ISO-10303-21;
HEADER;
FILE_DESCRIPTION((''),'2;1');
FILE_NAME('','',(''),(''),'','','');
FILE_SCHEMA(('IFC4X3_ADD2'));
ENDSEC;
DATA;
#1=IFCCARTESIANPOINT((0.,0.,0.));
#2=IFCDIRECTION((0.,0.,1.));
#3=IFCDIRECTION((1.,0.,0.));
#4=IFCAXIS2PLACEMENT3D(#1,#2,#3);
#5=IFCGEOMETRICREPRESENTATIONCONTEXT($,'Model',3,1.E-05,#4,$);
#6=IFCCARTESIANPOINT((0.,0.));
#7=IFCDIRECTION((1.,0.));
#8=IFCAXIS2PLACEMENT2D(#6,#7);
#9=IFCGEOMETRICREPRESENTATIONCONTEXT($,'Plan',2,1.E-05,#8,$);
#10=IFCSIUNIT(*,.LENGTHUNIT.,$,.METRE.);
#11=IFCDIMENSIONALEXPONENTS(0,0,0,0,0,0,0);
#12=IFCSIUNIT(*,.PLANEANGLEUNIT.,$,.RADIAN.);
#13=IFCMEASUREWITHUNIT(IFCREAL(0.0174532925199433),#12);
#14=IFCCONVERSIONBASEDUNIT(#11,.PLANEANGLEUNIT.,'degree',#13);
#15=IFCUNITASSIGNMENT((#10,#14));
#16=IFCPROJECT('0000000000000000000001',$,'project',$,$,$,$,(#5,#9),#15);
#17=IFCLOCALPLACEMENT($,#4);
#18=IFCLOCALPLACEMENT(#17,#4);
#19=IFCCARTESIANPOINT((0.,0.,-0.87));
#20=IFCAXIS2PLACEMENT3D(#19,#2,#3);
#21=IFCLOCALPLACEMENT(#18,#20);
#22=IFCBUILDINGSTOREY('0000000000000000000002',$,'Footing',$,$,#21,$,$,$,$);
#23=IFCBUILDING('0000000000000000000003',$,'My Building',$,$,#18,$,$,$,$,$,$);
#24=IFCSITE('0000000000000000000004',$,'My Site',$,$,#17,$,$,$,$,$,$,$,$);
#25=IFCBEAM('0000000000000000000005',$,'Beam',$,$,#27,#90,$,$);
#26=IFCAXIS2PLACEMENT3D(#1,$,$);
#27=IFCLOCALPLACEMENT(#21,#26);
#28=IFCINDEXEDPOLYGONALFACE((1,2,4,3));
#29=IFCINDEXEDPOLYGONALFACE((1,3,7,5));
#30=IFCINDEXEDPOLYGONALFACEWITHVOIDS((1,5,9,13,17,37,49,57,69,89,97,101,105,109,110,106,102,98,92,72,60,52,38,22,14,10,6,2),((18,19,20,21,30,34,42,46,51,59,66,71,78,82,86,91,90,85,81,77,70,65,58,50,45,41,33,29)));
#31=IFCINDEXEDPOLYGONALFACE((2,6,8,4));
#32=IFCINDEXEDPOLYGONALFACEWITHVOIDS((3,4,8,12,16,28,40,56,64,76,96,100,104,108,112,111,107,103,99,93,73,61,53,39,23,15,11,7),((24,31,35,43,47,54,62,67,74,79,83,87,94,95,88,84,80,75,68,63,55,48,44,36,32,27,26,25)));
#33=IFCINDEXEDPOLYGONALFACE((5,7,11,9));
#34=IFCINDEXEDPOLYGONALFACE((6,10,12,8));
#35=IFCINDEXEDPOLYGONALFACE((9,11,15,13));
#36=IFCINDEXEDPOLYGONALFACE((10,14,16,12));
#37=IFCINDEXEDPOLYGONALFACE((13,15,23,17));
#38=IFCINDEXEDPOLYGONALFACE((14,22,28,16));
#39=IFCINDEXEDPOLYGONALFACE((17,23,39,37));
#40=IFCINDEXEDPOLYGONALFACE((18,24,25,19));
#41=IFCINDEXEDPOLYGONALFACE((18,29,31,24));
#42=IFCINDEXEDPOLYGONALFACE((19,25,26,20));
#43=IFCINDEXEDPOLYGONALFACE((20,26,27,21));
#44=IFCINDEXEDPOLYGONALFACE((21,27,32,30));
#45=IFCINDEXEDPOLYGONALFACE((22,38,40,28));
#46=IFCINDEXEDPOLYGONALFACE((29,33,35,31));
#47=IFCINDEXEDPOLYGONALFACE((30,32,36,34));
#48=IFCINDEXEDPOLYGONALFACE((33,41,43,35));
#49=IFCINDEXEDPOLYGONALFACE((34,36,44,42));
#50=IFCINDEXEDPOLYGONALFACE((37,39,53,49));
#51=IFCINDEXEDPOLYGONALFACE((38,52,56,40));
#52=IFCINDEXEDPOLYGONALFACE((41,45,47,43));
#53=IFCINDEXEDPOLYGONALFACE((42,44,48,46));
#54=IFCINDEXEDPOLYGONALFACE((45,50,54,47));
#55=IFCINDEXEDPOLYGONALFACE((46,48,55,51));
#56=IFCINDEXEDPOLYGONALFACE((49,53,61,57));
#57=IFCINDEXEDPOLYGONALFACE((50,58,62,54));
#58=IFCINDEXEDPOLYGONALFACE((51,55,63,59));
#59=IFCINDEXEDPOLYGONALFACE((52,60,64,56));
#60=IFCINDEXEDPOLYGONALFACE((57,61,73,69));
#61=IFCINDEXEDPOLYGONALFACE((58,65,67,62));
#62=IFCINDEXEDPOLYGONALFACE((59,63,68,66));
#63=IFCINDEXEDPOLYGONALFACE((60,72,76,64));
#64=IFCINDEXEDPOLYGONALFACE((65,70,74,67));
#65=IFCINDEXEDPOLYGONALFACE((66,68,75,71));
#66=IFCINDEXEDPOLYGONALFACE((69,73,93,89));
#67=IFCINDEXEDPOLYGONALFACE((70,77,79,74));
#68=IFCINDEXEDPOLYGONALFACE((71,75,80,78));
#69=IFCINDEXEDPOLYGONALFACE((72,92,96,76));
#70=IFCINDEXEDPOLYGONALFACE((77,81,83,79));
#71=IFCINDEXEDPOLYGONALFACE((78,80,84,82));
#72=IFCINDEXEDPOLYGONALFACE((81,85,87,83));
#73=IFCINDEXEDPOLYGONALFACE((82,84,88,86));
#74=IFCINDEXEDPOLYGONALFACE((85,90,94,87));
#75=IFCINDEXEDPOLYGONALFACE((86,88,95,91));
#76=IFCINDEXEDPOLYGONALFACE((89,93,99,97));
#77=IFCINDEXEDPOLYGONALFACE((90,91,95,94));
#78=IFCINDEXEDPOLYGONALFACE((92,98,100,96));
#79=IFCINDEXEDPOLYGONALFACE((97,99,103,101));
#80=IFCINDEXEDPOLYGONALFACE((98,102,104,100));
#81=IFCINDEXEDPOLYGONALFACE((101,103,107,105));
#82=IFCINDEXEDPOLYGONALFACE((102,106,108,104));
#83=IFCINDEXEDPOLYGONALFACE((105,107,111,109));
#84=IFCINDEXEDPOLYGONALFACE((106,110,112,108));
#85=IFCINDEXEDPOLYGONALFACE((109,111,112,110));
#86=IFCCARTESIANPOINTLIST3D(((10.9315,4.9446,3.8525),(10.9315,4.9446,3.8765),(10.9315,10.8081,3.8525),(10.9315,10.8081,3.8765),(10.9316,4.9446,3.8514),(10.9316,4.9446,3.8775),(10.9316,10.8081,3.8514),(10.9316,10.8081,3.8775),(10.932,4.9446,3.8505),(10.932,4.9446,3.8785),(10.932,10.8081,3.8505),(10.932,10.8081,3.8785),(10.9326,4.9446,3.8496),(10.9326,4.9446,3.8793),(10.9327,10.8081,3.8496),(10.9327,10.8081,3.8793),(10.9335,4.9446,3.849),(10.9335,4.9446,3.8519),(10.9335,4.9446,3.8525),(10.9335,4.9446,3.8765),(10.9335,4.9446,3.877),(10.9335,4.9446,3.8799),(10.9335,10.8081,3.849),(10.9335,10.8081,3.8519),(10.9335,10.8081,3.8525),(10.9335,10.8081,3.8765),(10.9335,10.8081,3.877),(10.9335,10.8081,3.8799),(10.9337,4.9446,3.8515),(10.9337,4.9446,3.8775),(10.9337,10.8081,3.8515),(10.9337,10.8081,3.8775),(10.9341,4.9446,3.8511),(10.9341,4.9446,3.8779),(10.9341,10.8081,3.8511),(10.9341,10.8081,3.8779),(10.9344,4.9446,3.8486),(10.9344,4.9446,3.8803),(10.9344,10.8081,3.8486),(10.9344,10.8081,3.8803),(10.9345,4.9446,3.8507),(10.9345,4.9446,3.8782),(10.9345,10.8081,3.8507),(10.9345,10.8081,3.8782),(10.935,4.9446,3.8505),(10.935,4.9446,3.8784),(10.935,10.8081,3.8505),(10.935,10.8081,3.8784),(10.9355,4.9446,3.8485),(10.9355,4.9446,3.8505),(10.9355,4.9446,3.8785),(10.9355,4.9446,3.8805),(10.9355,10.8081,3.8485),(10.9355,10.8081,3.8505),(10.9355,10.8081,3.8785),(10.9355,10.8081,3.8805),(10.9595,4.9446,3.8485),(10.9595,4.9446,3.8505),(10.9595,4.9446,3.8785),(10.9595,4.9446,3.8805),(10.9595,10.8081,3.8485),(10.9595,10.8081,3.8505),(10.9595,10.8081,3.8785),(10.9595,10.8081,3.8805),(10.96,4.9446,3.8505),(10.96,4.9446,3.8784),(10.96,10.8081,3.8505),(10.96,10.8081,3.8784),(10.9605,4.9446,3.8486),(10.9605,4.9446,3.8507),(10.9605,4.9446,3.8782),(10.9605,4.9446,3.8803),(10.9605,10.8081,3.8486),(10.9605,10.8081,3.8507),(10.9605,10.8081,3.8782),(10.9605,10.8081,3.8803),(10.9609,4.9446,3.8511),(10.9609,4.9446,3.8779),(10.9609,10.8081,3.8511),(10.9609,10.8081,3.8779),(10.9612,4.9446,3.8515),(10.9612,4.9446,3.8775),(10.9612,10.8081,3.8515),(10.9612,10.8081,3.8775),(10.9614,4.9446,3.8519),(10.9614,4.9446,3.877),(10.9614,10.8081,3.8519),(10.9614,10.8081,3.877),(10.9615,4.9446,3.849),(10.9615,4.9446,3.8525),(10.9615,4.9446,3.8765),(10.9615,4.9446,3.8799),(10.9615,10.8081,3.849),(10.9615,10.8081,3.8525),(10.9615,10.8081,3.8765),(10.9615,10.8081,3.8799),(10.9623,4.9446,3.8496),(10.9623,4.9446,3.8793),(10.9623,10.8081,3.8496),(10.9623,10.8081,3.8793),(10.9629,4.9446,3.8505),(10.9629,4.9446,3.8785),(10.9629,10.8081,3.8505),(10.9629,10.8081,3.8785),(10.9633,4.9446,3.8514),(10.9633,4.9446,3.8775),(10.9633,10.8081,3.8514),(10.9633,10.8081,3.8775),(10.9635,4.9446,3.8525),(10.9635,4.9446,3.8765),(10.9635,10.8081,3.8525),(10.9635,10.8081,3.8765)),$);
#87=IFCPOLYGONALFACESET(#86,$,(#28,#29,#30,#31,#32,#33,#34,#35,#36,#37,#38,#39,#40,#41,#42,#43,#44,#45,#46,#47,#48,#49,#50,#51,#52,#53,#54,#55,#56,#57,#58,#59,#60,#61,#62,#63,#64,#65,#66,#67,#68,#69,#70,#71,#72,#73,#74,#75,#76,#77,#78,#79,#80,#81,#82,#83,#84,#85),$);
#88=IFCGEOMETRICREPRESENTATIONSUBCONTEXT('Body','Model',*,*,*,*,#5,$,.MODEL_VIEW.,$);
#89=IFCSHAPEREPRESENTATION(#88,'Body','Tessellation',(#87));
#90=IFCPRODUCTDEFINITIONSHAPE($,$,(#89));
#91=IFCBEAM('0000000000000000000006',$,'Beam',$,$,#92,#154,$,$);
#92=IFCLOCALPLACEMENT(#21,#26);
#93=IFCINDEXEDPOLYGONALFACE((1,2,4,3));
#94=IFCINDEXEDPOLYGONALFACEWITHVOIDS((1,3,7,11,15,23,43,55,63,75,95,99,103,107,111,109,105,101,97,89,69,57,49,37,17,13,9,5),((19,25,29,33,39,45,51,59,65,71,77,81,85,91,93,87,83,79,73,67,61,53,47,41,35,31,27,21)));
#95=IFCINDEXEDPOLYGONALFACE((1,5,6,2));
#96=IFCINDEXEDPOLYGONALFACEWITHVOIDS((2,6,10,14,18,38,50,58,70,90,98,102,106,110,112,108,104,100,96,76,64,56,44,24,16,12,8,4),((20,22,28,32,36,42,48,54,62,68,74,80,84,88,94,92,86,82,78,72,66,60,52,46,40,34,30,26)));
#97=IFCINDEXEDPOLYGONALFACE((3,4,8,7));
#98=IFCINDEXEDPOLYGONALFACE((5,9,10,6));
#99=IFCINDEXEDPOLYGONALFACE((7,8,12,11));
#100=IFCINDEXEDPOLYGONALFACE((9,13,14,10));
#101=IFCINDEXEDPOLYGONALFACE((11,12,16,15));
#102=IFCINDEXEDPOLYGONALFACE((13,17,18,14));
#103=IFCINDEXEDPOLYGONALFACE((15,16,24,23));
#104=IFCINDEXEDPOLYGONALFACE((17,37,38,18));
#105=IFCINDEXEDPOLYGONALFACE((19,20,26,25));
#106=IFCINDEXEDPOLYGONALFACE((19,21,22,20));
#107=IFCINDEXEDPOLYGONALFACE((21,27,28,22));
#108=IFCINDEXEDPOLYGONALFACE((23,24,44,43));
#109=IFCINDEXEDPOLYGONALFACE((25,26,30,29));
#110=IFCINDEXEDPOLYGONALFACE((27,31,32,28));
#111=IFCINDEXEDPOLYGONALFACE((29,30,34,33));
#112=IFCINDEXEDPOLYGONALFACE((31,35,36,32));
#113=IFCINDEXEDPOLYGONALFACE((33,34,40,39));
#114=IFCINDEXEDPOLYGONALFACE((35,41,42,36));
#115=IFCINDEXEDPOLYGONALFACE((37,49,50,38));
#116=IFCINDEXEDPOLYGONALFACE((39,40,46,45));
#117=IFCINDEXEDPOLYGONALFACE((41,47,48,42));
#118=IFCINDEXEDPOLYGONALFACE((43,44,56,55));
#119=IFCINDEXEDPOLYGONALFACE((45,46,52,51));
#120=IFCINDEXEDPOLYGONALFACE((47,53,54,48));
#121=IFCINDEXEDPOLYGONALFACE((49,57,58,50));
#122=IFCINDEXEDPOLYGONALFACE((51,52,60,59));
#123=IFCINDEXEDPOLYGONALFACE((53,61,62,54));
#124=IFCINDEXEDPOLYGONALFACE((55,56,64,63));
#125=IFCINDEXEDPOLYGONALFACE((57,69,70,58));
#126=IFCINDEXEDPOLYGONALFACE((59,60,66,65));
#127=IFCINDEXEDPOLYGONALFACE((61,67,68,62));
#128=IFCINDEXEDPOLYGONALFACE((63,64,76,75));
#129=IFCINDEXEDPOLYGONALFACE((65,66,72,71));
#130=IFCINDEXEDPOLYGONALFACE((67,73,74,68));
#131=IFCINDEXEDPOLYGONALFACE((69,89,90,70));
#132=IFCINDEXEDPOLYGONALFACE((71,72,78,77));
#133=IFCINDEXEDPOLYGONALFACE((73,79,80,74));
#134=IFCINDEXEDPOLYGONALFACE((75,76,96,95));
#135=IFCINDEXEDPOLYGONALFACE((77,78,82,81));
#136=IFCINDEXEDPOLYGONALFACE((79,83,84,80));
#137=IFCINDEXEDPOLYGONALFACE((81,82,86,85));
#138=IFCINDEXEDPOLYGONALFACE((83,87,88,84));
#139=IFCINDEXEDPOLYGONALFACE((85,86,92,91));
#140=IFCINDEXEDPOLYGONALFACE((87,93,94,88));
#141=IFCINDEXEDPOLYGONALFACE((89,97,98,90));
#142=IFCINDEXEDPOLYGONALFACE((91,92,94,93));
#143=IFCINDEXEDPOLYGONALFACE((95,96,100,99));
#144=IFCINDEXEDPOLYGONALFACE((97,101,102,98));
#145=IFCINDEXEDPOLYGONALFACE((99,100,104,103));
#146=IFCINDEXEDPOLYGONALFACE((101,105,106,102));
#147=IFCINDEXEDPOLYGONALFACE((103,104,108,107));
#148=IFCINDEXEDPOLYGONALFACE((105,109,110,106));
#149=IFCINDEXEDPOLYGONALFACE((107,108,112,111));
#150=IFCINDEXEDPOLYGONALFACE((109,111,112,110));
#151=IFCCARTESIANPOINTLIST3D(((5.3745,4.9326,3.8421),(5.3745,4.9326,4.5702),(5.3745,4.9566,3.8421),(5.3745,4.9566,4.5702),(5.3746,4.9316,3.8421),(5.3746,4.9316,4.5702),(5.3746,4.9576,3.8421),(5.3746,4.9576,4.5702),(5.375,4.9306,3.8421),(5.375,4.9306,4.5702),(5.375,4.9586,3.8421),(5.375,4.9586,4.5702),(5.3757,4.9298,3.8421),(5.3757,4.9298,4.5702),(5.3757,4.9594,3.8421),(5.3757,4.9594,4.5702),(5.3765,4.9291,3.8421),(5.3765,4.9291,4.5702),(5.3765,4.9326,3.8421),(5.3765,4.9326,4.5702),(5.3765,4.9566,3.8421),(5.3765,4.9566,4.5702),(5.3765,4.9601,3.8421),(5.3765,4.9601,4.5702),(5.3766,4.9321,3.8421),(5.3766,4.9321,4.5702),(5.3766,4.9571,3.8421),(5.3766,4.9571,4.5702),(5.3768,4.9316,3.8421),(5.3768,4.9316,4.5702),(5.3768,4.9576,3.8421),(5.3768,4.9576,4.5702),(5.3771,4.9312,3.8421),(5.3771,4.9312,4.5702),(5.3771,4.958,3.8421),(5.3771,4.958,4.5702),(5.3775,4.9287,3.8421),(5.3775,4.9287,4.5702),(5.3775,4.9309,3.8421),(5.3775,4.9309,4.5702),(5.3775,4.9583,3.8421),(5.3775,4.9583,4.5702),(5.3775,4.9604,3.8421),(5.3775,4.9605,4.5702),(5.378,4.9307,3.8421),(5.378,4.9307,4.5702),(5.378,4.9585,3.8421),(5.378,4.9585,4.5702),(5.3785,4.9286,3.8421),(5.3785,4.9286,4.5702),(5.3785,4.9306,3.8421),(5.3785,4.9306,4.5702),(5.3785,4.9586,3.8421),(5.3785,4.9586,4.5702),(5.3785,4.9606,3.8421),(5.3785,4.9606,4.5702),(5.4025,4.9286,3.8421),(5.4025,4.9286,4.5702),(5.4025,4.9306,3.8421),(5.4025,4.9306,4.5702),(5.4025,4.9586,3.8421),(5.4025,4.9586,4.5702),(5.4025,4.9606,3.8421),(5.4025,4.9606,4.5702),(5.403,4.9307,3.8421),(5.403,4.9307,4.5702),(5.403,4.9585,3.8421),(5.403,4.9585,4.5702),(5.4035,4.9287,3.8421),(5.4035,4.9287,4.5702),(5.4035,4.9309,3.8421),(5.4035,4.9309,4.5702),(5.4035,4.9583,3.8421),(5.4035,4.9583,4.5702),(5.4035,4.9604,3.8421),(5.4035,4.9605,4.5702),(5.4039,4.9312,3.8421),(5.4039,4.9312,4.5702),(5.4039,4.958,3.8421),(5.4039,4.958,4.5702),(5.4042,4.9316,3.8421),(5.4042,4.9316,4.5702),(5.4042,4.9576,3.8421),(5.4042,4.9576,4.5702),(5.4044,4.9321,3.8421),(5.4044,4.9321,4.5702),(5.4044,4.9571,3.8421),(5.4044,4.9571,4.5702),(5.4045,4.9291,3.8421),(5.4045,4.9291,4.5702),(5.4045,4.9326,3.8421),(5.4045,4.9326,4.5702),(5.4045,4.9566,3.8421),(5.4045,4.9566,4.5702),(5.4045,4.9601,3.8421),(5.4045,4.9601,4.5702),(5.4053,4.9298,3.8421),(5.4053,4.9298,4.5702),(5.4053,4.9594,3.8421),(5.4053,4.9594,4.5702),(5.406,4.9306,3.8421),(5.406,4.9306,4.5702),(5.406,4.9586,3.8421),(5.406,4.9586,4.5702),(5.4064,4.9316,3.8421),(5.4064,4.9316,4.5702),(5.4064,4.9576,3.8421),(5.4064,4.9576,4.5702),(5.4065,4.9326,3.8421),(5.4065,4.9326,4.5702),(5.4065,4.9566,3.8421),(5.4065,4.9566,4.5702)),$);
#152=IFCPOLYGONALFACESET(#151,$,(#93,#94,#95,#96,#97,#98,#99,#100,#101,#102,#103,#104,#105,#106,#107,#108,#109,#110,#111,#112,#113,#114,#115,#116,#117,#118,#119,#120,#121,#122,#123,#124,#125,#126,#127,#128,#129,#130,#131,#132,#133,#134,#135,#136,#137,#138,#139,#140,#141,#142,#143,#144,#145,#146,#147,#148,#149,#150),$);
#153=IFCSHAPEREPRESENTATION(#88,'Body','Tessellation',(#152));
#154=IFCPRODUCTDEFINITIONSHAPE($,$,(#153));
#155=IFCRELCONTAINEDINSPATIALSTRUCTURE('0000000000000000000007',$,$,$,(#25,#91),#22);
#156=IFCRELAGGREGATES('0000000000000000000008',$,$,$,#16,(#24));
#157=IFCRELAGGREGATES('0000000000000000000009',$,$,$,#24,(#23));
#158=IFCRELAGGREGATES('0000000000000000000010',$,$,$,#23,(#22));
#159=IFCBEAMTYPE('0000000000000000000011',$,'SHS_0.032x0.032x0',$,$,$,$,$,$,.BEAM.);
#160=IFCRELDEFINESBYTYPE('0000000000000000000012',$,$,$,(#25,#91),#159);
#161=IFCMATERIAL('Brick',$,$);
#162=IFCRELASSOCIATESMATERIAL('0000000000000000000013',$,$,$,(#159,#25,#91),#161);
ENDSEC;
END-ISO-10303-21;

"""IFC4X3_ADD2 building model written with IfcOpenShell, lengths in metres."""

from ifc_helpers import new_model, entity, si_unit, converted_unit, frame, origin_with_axes, origin_2d_with_axis, place, context, subcontext, project, spatial, hollow_rectangle, extrude, material, material_profile, profile_set, profile_usage, type_object, element, save


model = new_model("IFC4X3_ADD2")

# Units and contexts
model_context = context("Model", 3, precision=1e-05, world=origin_with_axes())
plan_context = context("Plan", 2, precision=1e-05, world=origin_2d_with_axis())
body_context = subcontext(model_context, "Body", "Model", "MODEL_VIEW")
ifc_project = project(units=[si_unit("LENGTHUNIT", "METRE"), converted_unit("PLANEANGLEUNIT", "degree", entity("IfcReal", 0.0174532925199433), si_unit("PLANEANGLEUNIT", "RADIAN"), dimensions=[0, 0, 0, 0, 0, 0, 0])], contexts=[model_context, plan_context])

# Site, building, storey
site_placement = place(None, origin_with_axes())
site = spatial("IfcSite", under=ifc_project, at=site_placement, Name="My Site")
building_placement = place(site_placement, origin_with_axes())
building = spatial("IfcBuilding", under=site, at=building_placement, Name="My Building")
storey_placement = place(building_placement, frame((0.0, 0.0, -0.87), z_axis=(0.0, 0.0, 1.0), x_axis=(1.0, 0.0, 0.0)))
storey = spatial("IfcBuildingStorey", under=building, at=storey_placement, Name="Footing")

# Beams
ifc_material_1 = material(Name="Brick")
ifc_material_profile = material_profile(ifc_material_1, hollow_rectangle(XDim=0.032, YDim=0.032, WallThickness=0.002, InnerFilletRadius=0.002, OuterFilletRadius=0.004))
ifc_profile_set = profile_set([ifc_material_profile])
beam_type_1 = type_object("IfcBeamType", Name="SHS_0.032x0.032x0", PredefinedType="BEAM", material=ifc_profile_set)
ifc_profile_usage_1 = profile_usage(ifc_profile_set, cardinal=5)
beam_1_placement = place(storey_placement, frame((10.9475, 4.9446, 3.8645), z_axis=(0.0, 1.0, 0.0), x_axis=(-1.0, 0.0, 0.0)))
element("IfcBeam", 1, at=beam_1_placement, inside=storey, type_object=beam_type_1, material=ifc_profile_usage_1, Name="Beam", context=body_context, shape_type="SweptSolid", body=[
    extrude(hollow_rectangle(XDim=0.032, YDim=0.032, WallThickness=0.002, InnerFilletRadius=0.002, OuterFilletRadius=0.004), origin_with_axes(), (0.0, 0.0, 1.0), 5.8635),
])
ifc_profile_usage_2 = profile_usage(ifc_profile_set, cardinal=5)
beam_2_placement = place(storey_placement, frame((5.3905, 4.9446, 3.8421), z_axis=(0.0, 0.0, 1.0), x_axis=(1.0, 0.0, 0.0)))
element("IfcBeam", 2, at=beam_2_placement, inside=storey, type_object=beam_type_1, material=ifc_profile_usage_2, Name="Beam", context=body_context, shape_type="SweptSolid", body=[
    extrude(hollow_rectangle(XDim=0.032, YDim=0.032, WallThickness=0.002, InnerFilletRadius=0.002, OuterFilletRadius=0.004), origin_with_axes(), (0.0, 0.0, 1.0), 0.7281),
])

save(model, "model.ifc")
